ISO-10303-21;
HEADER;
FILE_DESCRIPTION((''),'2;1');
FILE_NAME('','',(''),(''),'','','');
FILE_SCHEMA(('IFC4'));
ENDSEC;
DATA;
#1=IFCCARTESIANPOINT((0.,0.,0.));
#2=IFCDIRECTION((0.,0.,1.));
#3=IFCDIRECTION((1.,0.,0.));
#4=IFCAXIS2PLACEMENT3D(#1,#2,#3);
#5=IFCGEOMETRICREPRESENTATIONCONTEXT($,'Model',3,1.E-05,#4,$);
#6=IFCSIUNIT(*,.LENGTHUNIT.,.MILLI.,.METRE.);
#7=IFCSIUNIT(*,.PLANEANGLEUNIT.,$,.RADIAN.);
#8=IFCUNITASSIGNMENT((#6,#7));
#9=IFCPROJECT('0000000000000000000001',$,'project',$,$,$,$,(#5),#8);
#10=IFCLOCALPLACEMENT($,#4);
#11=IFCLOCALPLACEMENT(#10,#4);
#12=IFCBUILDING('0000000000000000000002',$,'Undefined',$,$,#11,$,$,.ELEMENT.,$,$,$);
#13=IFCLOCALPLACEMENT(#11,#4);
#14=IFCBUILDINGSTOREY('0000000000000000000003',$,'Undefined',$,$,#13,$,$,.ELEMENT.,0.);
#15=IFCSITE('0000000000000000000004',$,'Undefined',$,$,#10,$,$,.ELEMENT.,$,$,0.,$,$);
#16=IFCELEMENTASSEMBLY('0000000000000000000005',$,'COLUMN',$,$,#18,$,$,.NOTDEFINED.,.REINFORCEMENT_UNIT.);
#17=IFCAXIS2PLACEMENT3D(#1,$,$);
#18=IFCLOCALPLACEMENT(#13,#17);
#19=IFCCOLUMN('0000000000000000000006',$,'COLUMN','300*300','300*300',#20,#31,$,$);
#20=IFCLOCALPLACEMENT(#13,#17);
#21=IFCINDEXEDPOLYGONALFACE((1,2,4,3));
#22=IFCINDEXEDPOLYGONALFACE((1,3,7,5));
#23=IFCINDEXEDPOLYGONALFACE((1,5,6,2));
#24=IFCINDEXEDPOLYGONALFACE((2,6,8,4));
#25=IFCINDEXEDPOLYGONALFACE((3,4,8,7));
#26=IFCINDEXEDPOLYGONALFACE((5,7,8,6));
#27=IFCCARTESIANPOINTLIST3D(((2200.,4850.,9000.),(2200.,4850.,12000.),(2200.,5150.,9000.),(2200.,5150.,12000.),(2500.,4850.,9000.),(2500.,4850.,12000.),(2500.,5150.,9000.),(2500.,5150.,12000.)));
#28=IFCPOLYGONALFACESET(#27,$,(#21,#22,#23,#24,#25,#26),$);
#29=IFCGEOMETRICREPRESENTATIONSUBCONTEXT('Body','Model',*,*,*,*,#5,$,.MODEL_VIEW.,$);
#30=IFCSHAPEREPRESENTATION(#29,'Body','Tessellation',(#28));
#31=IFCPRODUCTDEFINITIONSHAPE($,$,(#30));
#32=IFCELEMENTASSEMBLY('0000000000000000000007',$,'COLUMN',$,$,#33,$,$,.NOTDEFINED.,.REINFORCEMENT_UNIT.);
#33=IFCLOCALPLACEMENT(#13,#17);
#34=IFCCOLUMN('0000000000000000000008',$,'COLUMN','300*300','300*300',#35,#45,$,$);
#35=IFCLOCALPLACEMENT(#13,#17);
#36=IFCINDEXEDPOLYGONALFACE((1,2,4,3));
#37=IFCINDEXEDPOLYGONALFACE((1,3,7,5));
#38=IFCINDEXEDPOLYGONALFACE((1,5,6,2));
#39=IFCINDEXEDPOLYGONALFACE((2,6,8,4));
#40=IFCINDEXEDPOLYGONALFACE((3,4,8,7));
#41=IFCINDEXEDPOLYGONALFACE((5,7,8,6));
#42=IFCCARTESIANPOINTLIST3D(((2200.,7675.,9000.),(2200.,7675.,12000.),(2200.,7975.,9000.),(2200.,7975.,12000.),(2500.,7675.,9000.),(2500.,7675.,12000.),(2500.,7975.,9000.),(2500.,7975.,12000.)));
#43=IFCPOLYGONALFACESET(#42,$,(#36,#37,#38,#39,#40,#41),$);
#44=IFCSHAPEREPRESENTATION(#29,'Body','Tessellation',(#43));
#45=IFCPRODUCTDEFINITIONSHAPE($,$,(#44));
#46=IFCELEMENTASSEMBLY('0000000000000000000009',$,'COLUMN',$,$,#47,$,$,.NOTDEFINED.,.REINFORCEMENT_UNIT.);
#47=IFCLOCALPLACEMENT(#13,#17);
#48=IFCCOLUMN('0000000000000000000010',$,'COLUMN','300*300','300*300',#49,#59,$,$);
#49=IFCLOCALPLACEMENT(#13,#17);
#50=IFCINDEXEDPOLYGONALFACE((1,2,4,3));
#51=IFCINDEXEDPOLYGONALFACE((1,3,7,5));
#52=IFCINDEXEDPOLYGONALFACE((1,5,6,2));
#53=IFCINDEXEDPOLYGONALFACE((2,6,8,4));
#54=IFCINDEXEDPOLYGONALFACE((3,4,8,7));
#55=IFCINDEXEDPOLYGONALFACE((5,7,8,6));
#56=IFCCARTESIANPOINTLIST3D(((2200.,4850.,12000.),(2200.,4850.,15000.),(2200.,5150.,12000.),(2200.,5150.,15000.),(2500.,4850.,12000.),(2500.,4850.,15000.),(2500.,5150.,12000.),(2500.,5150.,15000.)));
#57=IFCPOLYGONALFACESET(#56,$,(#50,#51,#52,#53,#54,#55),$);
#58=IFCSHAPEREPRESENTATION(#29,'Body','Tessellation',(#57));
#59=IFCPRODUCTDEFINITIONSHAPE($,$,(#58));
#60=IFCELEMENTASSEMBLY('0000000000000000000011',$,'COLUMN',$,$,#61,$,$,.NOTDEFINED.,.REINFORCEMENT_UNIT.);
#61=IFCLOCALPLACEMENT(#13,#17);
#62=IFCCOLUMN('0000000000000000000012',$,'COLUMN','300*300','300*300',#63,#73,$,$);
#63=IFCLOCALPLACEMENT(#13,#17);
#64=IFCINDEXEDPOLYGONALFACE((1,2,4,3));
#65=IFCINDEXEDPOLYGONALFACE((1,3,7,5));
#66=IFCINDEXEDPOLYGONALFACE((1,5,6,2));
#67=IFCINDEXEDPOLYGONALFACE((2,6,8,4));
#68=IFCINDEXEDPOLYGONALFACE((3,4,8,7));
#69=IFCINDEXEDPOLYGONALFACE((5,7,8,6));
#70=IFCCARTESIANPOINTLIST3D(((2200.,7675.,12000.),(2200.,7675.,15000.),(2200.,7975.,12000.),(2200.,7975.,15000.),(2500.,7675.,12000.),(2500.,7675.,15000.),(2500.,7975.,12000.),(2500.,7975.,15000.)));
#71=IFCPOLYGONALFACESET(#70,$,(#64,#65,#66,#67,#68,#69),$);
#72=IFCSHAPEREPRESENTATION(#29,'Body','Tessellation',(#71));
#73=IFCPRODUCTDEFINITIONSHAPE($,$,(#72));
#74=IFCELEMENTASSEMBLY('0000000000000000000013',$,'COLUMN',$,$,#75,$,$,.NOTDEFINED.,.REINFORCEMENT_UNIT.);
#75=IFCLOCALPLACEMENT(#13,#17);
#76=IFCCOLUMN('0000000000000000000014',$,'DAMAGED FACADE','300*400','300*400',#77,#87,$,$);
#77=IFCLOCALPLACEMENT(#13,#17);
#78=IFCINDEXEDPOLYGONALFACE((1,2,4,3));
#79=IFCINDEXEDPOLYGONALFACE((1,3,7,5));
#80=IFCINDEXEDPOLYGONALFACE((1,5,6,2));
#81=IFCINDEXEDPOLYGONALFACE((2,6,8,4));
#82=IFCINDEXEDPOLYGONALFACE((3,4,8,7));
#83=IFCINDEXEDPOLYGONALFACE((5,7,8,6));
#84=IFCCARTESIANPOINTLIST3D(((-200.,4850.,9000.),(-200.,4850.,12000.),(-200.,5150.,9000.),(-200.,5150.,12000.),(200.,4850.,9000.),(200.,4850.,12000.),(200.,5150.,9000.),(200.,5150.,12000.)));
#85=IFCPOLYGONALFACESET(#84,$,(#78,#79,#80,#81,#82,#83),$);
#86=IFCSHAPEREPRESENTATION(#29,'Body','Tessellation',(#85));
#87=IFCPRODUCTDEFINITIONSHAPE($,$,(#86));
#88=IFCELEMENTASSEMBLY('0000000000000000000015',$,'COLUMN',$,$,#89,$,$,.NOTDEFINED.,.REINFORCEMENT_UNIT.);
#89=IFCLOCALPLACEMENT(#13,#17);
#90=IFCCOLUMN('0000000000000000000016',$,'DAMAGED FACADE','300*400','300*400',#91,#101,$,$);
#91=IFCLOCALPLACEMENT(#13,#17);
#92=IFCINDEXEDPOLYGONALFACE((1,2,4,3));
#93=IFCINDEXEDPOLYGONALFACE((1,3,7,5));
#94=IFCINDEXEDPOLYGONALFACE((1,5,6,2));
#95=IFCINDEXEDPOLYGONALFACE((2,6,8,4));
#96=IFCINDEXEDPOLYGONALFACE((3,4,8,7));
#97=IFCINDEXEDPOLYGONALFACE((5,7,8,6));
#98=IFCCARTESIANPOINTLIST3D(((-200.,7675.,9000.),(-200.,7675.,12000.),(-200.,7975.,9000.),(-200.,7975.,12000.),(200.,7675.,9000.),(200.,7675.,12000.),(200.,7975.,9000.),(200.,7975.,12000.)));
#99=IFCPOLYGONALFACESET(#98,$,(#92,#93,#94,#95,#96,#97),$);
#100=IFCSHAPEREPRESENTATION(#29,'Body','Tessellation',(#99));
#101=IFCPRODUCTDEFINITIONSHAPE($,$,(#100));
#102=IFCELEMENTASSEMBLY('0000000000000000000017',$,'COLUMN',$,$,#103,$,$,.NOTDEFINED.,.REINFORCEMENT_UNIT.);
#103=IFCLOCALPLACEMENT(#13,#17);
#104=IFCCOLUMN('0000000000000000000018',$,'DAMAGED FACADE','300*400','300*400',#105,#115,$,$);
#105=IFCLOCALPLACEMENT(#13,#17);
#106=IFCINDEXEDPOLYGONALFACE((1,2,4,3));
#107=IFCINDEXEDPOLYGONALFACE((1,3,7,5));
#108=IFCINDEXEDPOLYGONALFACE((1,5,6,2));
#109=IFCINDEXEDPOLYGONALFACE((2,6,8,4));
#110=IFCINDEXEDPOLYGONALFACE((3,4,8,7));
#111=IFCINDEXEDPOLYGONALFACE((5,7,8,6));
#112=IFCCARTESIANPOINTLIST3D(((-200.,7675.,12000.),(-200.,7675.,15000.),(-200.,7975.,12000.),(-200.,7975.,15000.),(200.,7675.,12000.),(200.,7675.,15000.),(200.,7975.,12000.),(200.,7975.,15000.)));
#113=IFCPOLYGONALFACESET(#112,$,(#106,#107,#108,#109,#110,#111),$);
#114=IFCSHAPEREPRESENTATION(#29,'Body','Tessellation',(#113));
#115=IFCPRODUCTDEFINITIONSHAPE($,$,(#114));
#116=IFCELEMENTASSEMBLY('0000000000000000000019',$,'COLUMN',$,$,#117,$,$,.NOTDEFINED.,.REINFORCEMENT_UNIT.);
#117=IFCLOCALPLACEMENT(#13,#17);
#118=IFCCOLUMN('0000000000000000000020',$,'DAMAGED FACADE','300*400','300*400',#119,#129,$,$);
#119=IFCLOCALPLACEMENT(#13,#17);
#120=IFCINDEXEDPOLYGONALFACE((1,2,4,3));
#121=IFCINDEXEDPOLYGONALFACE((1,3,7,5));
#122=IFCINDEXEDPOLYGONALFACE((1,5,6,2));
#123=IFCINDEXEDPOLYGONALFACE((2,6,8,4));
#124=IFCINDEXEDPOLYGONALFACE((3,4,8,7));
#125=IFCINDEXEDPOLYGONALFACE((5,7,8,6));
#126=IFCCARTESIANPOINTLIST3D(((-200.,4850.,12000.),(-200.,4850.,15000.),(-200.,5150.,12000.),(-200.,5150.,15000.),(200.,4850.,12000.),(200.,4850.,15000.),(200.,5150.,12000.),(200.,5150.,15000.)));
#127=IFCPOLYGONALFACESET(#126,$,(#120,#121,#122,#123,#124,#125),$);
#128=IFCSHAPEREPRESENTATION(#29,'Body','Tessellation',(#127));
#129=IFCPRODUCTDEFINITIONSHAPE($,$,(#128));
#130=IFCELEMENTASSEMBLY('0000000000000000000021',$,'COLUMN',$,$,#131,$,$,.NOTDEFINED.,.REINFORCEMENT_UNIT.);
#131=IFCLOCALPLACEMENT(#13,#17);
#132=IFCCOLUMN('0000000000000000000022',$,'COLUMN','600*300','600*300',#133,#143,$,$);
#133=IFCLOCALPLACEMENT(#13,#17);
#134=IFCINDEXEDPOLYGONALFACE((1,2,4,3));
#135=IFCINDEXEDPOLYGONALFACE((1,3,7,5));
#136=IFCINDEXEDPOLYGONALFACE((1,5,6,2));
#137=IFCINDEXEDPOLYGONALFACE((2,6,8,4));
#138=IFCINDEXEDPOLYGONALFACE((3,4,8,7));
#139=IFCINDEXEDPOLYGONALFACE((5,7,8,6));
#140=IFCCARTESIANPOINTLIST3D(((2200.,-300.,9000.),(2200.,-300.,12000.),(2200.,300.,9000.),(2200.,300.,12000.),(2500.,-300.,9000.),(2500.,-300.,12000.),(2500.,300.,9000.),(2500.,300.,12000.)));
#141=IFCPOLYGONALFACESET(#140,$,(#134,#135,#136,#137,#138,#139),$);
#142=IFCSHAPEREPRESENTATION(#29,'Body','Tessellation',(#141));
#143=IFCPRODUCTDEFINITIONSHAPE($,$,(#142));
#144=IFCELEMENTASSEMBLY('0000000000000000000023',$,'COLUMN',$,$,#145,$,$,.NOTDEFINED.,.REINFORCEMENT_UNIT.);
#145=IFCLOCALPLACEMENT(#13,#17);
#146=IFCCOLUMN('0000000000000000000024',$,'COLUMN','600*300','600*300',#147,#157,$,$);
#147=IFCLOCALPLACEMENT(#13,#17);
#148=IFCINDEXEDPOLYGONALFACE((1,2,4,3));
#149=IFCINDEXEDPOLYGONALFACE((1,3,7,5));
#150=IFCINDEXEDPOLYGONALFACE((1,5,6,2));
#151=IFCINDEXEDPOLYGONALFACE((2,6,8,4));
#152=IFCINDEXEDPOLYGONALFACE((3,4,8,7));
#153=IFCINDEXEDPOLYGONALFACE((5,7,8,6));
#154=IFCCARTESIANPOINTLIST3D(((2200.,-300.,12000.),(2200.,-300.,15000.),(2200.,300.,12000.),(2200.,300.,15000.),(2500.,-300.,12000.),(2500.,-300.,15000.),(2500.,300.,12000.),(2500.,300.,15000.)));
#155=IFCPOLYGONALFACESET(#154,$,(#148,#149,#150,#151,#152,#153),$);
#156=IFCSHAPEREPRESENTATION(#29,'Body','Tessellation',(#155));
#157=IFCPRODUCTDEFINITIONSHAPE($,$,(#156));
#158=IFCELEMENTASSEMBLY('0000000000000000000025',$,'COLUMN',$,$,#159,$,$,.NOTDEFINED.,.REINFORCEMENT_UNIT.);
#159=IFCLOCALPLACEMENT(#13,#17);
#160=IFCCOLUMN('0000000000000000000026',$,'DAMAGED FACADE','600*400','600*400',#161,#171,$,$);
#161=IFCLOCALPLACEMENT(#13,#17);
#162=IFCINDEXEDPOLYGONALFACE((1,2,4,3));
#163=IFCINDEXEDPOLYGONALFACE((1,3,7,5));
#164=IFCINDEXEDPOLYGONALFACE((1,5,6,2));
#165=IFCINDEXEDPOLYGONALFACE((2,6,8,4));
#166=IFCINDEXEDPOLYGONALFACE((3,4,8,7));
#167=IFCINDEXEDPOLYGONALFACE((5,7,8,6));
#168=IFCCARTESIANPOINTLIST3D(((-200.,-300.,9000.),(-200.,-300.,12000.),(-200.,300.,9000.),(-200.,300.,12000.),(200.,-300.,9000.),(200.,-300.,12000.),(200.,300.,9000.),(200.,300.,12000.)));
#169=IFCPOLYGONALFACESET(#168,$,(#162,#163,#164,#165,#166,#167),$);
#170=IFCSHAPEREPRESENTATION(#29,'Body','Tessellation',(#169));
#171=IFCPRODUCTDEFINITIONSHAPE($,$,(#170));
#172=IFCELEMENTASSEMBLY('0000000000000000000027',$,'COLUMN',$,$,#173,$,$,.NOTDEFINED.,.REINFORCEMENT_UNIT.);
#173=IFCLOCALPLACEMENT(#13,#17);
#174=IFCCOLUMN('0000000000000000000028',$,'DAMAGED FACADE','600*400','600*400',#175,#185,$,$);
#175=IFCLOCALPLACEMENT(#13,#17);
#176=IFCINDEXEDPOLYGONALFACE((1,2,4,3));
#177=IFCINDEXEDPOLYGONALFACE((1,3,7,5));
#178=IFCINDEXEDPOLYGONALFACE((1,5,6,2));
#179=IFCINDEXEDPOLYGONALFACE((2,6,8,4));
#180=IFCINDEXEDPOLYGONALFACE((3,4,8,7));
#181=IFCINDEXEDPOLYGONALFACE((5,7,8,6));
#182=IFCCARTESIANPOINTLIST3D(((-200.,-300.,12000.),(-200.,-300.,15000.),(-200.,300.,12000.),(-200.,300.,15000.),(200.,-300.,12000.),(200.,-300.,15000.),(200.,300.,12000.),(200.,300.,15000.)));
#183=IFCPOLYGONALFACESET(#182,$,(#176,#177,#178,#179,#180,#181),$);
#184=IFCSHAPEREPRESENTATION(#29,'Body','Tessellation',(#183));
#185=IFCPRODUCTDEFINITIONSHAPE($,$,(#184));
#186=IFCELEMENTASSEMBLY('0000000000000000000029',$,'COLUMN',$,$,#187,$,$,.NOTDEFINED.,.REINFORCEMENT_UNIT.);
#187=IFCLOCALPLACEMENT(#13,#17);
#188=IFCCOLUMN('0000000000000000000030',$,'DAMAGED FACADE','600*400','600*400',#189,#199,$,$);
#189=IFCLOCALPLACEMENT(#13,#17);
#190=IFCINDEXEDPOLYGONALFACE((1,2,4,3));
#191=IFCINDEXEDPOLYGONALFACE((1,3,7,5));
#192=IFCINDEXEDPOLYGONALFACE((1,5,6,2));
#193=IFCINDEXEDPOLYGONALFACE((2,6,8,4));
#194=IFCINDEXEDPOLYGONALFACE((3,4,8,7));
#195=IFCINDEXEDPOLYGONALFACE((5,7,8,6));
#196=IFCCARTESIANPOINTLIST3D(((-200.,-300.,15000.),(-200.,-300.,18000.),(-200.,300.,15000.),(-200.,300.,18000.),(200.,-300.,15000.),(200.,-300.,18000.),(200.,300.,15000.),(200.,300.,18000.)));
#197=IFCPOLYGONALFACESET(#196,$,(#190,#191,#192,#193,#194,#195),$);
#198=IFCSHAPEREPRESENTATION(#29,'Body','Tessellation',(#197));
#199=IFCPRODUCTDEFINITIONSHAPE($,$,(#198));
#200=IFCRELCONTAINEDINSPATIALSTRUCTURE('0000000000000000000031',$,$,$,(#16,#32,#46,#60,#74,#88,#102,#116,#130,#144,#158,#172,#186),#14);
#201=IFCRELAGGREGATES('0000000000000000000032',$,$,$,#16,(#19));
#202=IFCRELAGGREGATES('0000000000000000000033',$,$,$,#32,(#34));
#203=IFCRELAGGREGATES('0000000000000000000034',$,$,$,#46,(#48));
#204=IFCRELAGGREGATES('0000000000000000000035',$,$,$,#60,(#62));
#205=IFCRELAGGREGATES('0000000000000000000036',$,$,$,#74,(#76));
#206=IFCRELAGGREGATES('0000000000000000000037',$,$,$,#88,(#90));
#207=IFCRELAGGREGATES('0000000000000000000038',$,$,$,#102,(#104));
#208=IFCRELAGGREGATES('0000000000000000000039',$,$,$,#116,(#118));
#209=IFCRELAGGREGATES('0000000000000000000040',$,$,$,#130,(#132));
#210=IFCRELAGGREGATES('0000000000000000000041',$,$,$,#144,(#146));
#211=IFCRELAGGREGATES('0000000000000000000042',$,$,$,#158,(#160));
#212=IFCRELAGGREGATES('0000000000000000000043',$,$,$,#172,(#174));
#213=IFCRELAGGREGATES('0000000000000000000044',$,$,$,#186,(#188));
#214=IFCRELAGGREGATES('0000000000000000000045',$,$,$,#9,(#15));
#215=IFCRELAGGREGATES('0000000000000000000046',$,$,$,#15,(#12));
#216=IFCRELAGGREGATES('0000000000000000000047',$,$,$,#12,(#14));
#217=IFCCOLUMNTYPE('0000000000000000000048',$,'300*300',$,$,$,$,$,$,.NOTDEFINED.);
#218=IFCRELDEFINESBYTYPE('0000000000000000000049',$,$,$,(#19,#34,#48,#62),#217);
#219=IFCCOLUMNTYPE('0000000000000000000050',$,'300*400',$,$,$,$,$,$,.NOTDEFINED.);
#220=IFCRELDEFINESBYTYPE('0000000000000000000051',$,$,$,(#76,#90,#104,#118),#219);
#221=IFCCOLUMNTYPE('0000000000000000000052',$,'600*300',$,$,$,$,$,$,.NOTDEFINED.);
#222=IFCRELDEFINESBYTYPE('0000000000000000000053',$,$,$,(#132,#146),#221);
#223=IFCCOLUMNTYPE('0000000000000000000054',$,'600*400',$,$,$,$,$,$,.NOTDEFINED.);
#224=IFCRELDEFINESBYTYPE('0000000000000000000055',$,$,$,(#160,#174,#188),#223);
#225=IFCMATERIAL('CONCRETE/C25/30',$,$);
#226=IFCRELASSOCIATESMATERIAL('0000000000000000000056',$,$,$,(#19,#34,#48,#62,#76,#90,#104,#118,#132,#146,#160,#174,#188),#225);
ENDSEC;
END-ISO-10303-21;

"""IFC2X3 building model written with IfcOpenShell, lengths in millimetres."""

from ifc_helpers import new_model, si_unit, frame, origin_with_axes, origin_2d_with_axis, place, context, subcontext, project, spatial, rectangle, extrude, material, type_object, element, aggregate, save


model = new_model("IFC2X3")

# Units and contexts
model_context = context("Model", 3, precision=1e-05, world=origin_with_axes())
body_context = subcontext(model_context, "Body", "Model", "MODEL_VIEW")
ifc_project = project(units=[si_unit("LENGTHUNIT", "METRE", prefix="MILLI"), si_unit("PLANEANGLEUNIT", "RADIAN")], contexts=[model_context])

# Site, building, storey
site_placement = place(None, origin_with_axes())
site = spatial("IfcSite", under=ifc_project, at=site_placement, Name="Undefined", CompositionType="ELEMENT", RefElevation=0.0)
building_placement = place(site_placement, origin_with_axes())
building = spatial("IfcBuilding", under=site, at=building_placement, Name="Undefined", CompositionType="ELEMENT")
storey_placement = place(building_placement, origin_with_axes())
storey = spatial("IfcBuildingStorey", under=building, at=storey_placement, Name="Undefined", CompositionType="ELEMENT", Elevation=0.0)

# Element assemblies, columns
assembly_1_placement = place(storey_placement, origin_with_axes())
assembly_1 = element("IfcElementAssembly", 1, at=assembly_1_placement, inside=storey, Name="COLUMN", AssemblyPlace="NOTDEFINED", PredefinedType="REINFORCEMENT_UNIT")
ifc_material_1 = material(Name="CONCRETE/C25/30")
column_type_1 = type_object("IfcColumnType", Name="300*300", PredefinedType="NOTDEFINED")
column_1_placement = place(assembly_1_placement, frame((2350.0, 5000.0, 9000.0), z_axis=(0.0, 0.0, 1.0), x_axis=(1.0, 0.0, 0.0)))
column_1 = element("IfcColumn", 2, at=column_1_placement, type_object=column_type_1, material=ifc_material_1, Name="COLUMN", Description="300*300", ObjectType="300*300", context=body_context, shape_type="SweptSolid", body=[
    extrude(rectangle(XDim=300.0, YDim=300.0, at=origin_2d_with_axis()), frame((0.0, 0.0, 3000.0), z_axis=(0.0, 0.0, -1.0), x_axis=(-1.0, 0.0, 0.0)), (0.0, 0.0, 1.0), 3000.0),
])
aggregate(assembly_1, [column_1])
assembly_2_placement = place(storey_placement, origin_with_axes())
assembly_2 = element("IfcElementAssembly", 3, at=assembly_2_placement, inside=storey, Name="COLUMN", AssemblyPlace="NOTDEFINED", PredefinedType="REINFORCEMENT_UNIT")
column_2_placement = place(assembly_2_placement, frame((2350.0, 7825.0, 9000.0), z_axis=(0.0, 0.0, 1.0), x_axis=(1.0, 0.0, 0.0)))
column_2 = element("IfcColumn", 4, at=column_2_placement, type_object=column_type_1, material=ifc_material_1, Name="COLUMN", Description="300*300", ObjectType="300*300", context=body_context, shape_type="SweptSolid", body=[
    extrude(rectangle(XDim=300.0, YDim=300.0, at=origin_2d_with_axis()), frame((0.0, 0.0, 3000.0), z_axis=(0.0, 0.0, -1.0), x_axis=(-1.0, 0.0, 0.0)), (0.0, 0.0, 1.0), 3000.0),
])
aggregate(assembly_2, [column_2])
assembly_3_placement = place(storey_placement, origin_with_axes())
assembly_3 = element("IfcElementAssembly", 5, at=assembly_3_placement, inside=storey, Name="COLUMN", AssemblyPlace="NOTDEFINED", PredefinedType="REINFORCEMENT_UNIT")
column_3_placement = place(assembly_3_placement, frame((2350.0, 5000.0, 12000.0), z_axis=(0.0, 0.0, 1.0), x_axis=(1.0, 0.0, 0.0)))
column_3 = element("IfcColumn", 6, at=column_3_placement, type_object=column_type_1, material=ifc_material_1, Name="COLUMN", Description="300*300", ObjectType="300*300", context=body_context, shape_type="SweptSolid", body=[
    extrude(rectangle(XDim=300.0, YDim=300.0, at=origin_2d_with_axis()), frame((0.0, 0.0, 3000.0), z_axis=(0.0, 0.0, -1.0), x_axis=(-1.0, 0.0, 0.0)), (0.0, 0.0, 1.0), 3000.0),
])
aggregate(assembly_3, [column_3])
assembly_4_placement = place(storey_placement, origin_with_axes())
assembly_4 = element("IfcElementAssembly", 7, at=assembly_4_placement, inside=storey, Name="COLUMN", AssemblyPlace="NOTDEFINED", PredefinedType="REINFORCEMENT_UNIT")
column_4_placement = place(assembly_4_placement, frame((2350.0, 7825.0, 12000.0), z_axis=(0.0, 0.0, 1.0), x_axis=(1.0, 0.0, 0.0)))
column_4 = element("IfcColumn", 8, at=column_4_placement, type_object=column_type_1, material=ifc_material_1, Name="COLUMN", Description="300*300", ObjectType="300*300", context=body_context, shape_type="SweptSolid", body=[
    extrude(rectangle(XDim=300.0, YDim=300.0, at=origin_2d_with_axis()), frame((0.0, 0.0, 3000.0), z_axis=(0.0, 0.0, -1.0), x_axis=(-1.0, 0.0, 0.0)), (0.0, 0.0, 1.0), 3000.0),
])
aggregate(assembly_4, [column_4])
assembly_5_placement = place(storey_placement, origin_with_axes())
assembly_5 = element("IfcElementAssembly", 9, at=assembly_5_placement, inside=storey, Name="COLUMN", AssemblyPlace="NOTDEFINED", PredefinedType="REINFORCEMENT_UNIT")
column_type_2 = type_object("IfcColumnType", Name="300*400", PredefinedType="NOTDEFINED")
column_5_placement = place(assembly_5_placement, frame((0.0, 5000.0, 9000.0), z_axis=(0.0, 0.0, 1.0), x_axis=(1.0, 0.0, 0.0)))
column_5 = element("IfcColumn", 10, at=column_5_placement, type_object=column_type_2, material=ifc_material_1, Name="DAMAGED FACADE", Description="300*400", ObjectType="300*400", context=body_context, shape_type="SweptSolid", body=[
    extrude(rectangle(XDim=400.0, YDim=300.0, at=origin_2d_with_axis()), frame((0.0, 0.0, 3000.0), z_axis=(0.0, 0.0, -1.0), x_axis=(-1.0, 0.0, 0.0)), (0.0, 0.0, 1.0), 3000.0),
])
aggregate(assembly_5, [column_5])
assembly_6_placement = place(storey_placement, origin_with_axes())
assembly_6 = element("IfcElementAssembly", 11, at=assembly_6_placement, inside=storey, Name="COLUMN", AssemblyPlace="NOTDEFINED", PredefinedType="REINFORCEMENT_UNIT")
column_6_placement = place(assembly_6_placement, frame((0.0, 7825.0, 9000.0), z_axis=(0.0, 0.0, 1.0), x_axis=(1.0, 0.0, 0.0)))
column_6 = element("IfcColumn", 12, at=column_6_placement, type_object=column_type_2, material=ifc_material_1, Name="DAMAGED FACADE", Description="300*400", ObjectType="300*400", context=body_context, shape_type="SweptSolid", body=[
    extrude(rectangle(XDim=400.0, YDim=300.0, at=origin_2d_with_axis()), frame((0.0, 0.0, 3000.0), z_axis=(0.0, 0.0, -1.0), x_axis=(-1.0, 0.0, 0.0)), (0.0, 0.0, 1.0), 3000.0),
])
aggregate(assembly_6, [column_6])
assembly_7_placement = place(storey_placement, origin_with_axes())
assembly_7 = element("IfcElementAssembly", 13, at=assembly_7_placement, inside=storey, Name="COLUMN", AssemblyPlace="NOTDEFINED", PredefinedType="REINFORCEMENT_UNIT")
column_7_placement = place(assembly_7_placement, frame((0.0, 7825.0, 12000.0), z_axis=(0.0, 0.0, 1.0), x_axis=(1.0, 0.0, 0.0)))
column_7 = element("IfcColumn", 14, at=column_7_placement, type_object=column_type_2, material=ifc_material_1, Name="DAMAGED FACADE", Description="300*400", ObjectType="300*400", context=body_context, shape_type="SweptSolid", body=[
    extrude(rectangle(XDim=400.0, YDim=300.0, at=origin_2d_with_axis()), frame((0.0, 0.0, 3000.0), z_axis=(0.0, 0.0, -1.0), x_axis=(-1.0, 0.0, 0.0)), (0.0, 0.0, 1.0), 3000.0),
])
aggregate(assembly_7, [column_7])
assembly_8_placement = place(storey_placement, origin_with_axes())
assembly_8 = element("IfcElementAssembly", 15, at=assembly_8_placement, inside=storey, Name="COLUMN", AssemblyPlace="NOTDEFINED", PredefinedType="REINFORCEMENT_UNIT")
column_8_placement = place(assembly_8_placement, frame((0.0, 5000.0, 12000.0), z_axis=(0.0, 0.0, 1.0), x_axis=(1.0, 0.0, 0.0)))
column_8 = element("IfcColumn", 16, at=column_8_placement, type_object=column_type_2, material=ifc_material_1, Name="DAMAGED FACADE", Description="300*400", ObjectType="300*400", context=body_context, shape_type="SweptSolid", body=[
    extrude(rectangle(XDim=400.0, YDim=300.0, at=origin_2d_with_axis()), frame((0.0, 0.0, 3000.0), z_axis=(0.0, 0.0, -1.0), x_axis=(-1.0, 0.0, 0.0)), (0.0, 0.0, 1.0), 3000.0),
])
aggregate(assembly_8, [column_8])
assembly_9_placement = place(storey_placement, origin_with_axes())
assembly_9 = element("IfcElementAssembly", 17, at=assembly_9_placement, inside=storey, Name="COLUMN", AssemblyPlace="NOTDEFINED", PredefinedType="REINFORCEMENT_UNIT")
column_type_3 = type_object("IfcColumnType", Name="600*300", PredefinedType="NOTDEFINED")
column_9_placement = place(assembly_9_placement, frame((2350.0, 0.0, 9000.0), z_axis=(0.0, 0.0, 1.0), x_axis=(1.0, 0.0, 0.0)))
column_9 = element("IfcColumn", 18, at=column_9_placement, type_object=column_type_3, material=ifc_material_1, Name="COLUMN", Description="600*300", ObjectType="600*300", context=body_context, shape_type="SweptSolid", body=[
    extrude(rectangle(XDim=300.0, YDim=600.0, at=origin_2d_with_axis()), frame((0.0, 0.0, 3000.0), z_axis=(0.0, 0.0, -1.0), x_axis=(-1.0, 0.0, 0.0)), (0.0, 0.0, 1.0), 3000.0),
])
aggregate(assembly_9, [column_9])
assembly_10_placement = place(storey_placement, origin_with_axes())
assembly_10 = element("IfcElementAssembly", 19, at=assembly_10_placement, inside=storey, Name="COLUMN", AssemblyPlace="NOTDEFINED", PredefinedType="REINFORCEMENT_UNIT")
column_10_placement = place(assembly_10_placement, frame((2350.0, 0.0, 12000.0), z_axis=(0.0, 0.0, 1.0), x_axis=(1.0, 0.0, 0.0)))
column_10 = element("IfcColumn", 20, at=column_10_placement, type_object=column_type_3, material=ifc_material_1, Name="COLUMN", Description="600*300", ObjectType="600*300", context=body_context, shape_type="SweptSolid", body=[
    extrude(rectangle(XDim=300.0, YDim=600.0, at=origin_2d_with_axis()), frame((0.0, 0.0, 3000.0), z_axis=(0.0, 0.0, -1.0), x_axis=(-1.0, 0.0, 0.0)), (0.0, 0.0, 1.0), 3000.0),
])
aggregate(assembly_10, [column_10])
assembly_11_placement = place(storey_placement, origin_with_axes())
assembly_11 = element("IfcElementAssembly", 21, at=assembly_11_placement, inside=storey, Name="COLUMN", AssemblyPlace="NOTDEFINED", PredefinedType="REINFORCEMENT_UNIT")
column_type_4 = type_object("IfcColumnType", Name="600*400", PredefinedType="NOTDEFINED")
column_11_placement = place(assembly_11_placement, frame((0.0, 0.0, 9000.0), z_axis=(0.0, 0.0, 1.0), x_axis=(1.0, 0.0, 0.0)))
column_11 = element("IfcColumn", 22, at=column_11_placement, type_object=column_type_4, material=ifc_material_1, Name="DAMAGED FACADE", Description="600*400", ObjectType="600*400", context=body_context, shape_type="SweptSolid", body=[
    extrude(rectangle(XDim=400.0, YDim=600.0, at=origin_2d_with_axis()), frame((0.0, 0.0, 3000.0), z_axis=(0.0, 0.0, -1.0), x_axis=(-1.0, 0.0, 0.0)), (0.0, 0.0, 1.0), 3000.0),
])
aggregate(assembly_11, [column_11])
assembly_12_placement = place(storey_placement, origin_with_axes())
assembly_12 = element("IfcElementAssembly", 23, at=assembly_12_placement, inside=storey, Name="COLUMN", AssemblyPlace="NOTDEFINED", PredefinedType="REINFORCEMENT_UNIT")
column_12_placement = place(assembly_12_placement, frame((0.0, 0.0, 12000.0), z_axis=(0.0, 0.0, 1.0), x_axis=(1.0, 0.0, 0.0)))
column_12 = element("IfcColumn", 24, at=column_12_placement, type_object=column_type_4, material=ifc_material_1, Name="DAMAGED FACADE", Description="600*400", ObjectType="600*400", context=body_context, shape_type="SweptSolid", body=[
    extrude(rectangle(XDim=400.0, YDim=600.0, at=origin_2d_with_axis()), frame((0.0, 0.0, 3000.0), z_axis=(0.0, 0.0, -1.0), x_axis=(-1.0, 0.0, 0.0)), (0.0, 0.0, 1.0), 3000.0),
])
aggregate(assembly_12, [column_12])
assembly_13_placement = place(storey_placement, origin_with_axes())
assembly_13 = element("IfcElementAssembly", 25, at=assembly_13_placement, inside=storey, Name="COLUMN", AssemblyPlace="NOTDEFINED", PredefinedType="REINFORCEMENT_UNIT")
column_13_placement = place(assembly_13_placement, frame((0.0, 0.0, 15000.0), z_axis=(0.0, 0.0, 1.0), x_axis=(1.0, 0.0, 0.0)))
column_13 = element("IfcColumn", 26, at=column_13_placement, type_object=column_type_4, material=ifc_material_1, Name="DAMAGED FACADE", Description="600*400", ObjectType="600*400", context=body_context, shape_type="SweptSolid", body=[
    extrude(rectangle(XDim=400.0, YDim=600.0, at=origin_2d_with_axis()), frame((0.0, 0.0, 3000.0), z_axis=(0.0, 0.0, -1.0), x_axis=(-1.0, 0.0, 0.0)), (0.0, 0.0, 1.0), 3000.0),
])
aggregate(assembly_13, [column_13])

save(model, "model.ifc")
